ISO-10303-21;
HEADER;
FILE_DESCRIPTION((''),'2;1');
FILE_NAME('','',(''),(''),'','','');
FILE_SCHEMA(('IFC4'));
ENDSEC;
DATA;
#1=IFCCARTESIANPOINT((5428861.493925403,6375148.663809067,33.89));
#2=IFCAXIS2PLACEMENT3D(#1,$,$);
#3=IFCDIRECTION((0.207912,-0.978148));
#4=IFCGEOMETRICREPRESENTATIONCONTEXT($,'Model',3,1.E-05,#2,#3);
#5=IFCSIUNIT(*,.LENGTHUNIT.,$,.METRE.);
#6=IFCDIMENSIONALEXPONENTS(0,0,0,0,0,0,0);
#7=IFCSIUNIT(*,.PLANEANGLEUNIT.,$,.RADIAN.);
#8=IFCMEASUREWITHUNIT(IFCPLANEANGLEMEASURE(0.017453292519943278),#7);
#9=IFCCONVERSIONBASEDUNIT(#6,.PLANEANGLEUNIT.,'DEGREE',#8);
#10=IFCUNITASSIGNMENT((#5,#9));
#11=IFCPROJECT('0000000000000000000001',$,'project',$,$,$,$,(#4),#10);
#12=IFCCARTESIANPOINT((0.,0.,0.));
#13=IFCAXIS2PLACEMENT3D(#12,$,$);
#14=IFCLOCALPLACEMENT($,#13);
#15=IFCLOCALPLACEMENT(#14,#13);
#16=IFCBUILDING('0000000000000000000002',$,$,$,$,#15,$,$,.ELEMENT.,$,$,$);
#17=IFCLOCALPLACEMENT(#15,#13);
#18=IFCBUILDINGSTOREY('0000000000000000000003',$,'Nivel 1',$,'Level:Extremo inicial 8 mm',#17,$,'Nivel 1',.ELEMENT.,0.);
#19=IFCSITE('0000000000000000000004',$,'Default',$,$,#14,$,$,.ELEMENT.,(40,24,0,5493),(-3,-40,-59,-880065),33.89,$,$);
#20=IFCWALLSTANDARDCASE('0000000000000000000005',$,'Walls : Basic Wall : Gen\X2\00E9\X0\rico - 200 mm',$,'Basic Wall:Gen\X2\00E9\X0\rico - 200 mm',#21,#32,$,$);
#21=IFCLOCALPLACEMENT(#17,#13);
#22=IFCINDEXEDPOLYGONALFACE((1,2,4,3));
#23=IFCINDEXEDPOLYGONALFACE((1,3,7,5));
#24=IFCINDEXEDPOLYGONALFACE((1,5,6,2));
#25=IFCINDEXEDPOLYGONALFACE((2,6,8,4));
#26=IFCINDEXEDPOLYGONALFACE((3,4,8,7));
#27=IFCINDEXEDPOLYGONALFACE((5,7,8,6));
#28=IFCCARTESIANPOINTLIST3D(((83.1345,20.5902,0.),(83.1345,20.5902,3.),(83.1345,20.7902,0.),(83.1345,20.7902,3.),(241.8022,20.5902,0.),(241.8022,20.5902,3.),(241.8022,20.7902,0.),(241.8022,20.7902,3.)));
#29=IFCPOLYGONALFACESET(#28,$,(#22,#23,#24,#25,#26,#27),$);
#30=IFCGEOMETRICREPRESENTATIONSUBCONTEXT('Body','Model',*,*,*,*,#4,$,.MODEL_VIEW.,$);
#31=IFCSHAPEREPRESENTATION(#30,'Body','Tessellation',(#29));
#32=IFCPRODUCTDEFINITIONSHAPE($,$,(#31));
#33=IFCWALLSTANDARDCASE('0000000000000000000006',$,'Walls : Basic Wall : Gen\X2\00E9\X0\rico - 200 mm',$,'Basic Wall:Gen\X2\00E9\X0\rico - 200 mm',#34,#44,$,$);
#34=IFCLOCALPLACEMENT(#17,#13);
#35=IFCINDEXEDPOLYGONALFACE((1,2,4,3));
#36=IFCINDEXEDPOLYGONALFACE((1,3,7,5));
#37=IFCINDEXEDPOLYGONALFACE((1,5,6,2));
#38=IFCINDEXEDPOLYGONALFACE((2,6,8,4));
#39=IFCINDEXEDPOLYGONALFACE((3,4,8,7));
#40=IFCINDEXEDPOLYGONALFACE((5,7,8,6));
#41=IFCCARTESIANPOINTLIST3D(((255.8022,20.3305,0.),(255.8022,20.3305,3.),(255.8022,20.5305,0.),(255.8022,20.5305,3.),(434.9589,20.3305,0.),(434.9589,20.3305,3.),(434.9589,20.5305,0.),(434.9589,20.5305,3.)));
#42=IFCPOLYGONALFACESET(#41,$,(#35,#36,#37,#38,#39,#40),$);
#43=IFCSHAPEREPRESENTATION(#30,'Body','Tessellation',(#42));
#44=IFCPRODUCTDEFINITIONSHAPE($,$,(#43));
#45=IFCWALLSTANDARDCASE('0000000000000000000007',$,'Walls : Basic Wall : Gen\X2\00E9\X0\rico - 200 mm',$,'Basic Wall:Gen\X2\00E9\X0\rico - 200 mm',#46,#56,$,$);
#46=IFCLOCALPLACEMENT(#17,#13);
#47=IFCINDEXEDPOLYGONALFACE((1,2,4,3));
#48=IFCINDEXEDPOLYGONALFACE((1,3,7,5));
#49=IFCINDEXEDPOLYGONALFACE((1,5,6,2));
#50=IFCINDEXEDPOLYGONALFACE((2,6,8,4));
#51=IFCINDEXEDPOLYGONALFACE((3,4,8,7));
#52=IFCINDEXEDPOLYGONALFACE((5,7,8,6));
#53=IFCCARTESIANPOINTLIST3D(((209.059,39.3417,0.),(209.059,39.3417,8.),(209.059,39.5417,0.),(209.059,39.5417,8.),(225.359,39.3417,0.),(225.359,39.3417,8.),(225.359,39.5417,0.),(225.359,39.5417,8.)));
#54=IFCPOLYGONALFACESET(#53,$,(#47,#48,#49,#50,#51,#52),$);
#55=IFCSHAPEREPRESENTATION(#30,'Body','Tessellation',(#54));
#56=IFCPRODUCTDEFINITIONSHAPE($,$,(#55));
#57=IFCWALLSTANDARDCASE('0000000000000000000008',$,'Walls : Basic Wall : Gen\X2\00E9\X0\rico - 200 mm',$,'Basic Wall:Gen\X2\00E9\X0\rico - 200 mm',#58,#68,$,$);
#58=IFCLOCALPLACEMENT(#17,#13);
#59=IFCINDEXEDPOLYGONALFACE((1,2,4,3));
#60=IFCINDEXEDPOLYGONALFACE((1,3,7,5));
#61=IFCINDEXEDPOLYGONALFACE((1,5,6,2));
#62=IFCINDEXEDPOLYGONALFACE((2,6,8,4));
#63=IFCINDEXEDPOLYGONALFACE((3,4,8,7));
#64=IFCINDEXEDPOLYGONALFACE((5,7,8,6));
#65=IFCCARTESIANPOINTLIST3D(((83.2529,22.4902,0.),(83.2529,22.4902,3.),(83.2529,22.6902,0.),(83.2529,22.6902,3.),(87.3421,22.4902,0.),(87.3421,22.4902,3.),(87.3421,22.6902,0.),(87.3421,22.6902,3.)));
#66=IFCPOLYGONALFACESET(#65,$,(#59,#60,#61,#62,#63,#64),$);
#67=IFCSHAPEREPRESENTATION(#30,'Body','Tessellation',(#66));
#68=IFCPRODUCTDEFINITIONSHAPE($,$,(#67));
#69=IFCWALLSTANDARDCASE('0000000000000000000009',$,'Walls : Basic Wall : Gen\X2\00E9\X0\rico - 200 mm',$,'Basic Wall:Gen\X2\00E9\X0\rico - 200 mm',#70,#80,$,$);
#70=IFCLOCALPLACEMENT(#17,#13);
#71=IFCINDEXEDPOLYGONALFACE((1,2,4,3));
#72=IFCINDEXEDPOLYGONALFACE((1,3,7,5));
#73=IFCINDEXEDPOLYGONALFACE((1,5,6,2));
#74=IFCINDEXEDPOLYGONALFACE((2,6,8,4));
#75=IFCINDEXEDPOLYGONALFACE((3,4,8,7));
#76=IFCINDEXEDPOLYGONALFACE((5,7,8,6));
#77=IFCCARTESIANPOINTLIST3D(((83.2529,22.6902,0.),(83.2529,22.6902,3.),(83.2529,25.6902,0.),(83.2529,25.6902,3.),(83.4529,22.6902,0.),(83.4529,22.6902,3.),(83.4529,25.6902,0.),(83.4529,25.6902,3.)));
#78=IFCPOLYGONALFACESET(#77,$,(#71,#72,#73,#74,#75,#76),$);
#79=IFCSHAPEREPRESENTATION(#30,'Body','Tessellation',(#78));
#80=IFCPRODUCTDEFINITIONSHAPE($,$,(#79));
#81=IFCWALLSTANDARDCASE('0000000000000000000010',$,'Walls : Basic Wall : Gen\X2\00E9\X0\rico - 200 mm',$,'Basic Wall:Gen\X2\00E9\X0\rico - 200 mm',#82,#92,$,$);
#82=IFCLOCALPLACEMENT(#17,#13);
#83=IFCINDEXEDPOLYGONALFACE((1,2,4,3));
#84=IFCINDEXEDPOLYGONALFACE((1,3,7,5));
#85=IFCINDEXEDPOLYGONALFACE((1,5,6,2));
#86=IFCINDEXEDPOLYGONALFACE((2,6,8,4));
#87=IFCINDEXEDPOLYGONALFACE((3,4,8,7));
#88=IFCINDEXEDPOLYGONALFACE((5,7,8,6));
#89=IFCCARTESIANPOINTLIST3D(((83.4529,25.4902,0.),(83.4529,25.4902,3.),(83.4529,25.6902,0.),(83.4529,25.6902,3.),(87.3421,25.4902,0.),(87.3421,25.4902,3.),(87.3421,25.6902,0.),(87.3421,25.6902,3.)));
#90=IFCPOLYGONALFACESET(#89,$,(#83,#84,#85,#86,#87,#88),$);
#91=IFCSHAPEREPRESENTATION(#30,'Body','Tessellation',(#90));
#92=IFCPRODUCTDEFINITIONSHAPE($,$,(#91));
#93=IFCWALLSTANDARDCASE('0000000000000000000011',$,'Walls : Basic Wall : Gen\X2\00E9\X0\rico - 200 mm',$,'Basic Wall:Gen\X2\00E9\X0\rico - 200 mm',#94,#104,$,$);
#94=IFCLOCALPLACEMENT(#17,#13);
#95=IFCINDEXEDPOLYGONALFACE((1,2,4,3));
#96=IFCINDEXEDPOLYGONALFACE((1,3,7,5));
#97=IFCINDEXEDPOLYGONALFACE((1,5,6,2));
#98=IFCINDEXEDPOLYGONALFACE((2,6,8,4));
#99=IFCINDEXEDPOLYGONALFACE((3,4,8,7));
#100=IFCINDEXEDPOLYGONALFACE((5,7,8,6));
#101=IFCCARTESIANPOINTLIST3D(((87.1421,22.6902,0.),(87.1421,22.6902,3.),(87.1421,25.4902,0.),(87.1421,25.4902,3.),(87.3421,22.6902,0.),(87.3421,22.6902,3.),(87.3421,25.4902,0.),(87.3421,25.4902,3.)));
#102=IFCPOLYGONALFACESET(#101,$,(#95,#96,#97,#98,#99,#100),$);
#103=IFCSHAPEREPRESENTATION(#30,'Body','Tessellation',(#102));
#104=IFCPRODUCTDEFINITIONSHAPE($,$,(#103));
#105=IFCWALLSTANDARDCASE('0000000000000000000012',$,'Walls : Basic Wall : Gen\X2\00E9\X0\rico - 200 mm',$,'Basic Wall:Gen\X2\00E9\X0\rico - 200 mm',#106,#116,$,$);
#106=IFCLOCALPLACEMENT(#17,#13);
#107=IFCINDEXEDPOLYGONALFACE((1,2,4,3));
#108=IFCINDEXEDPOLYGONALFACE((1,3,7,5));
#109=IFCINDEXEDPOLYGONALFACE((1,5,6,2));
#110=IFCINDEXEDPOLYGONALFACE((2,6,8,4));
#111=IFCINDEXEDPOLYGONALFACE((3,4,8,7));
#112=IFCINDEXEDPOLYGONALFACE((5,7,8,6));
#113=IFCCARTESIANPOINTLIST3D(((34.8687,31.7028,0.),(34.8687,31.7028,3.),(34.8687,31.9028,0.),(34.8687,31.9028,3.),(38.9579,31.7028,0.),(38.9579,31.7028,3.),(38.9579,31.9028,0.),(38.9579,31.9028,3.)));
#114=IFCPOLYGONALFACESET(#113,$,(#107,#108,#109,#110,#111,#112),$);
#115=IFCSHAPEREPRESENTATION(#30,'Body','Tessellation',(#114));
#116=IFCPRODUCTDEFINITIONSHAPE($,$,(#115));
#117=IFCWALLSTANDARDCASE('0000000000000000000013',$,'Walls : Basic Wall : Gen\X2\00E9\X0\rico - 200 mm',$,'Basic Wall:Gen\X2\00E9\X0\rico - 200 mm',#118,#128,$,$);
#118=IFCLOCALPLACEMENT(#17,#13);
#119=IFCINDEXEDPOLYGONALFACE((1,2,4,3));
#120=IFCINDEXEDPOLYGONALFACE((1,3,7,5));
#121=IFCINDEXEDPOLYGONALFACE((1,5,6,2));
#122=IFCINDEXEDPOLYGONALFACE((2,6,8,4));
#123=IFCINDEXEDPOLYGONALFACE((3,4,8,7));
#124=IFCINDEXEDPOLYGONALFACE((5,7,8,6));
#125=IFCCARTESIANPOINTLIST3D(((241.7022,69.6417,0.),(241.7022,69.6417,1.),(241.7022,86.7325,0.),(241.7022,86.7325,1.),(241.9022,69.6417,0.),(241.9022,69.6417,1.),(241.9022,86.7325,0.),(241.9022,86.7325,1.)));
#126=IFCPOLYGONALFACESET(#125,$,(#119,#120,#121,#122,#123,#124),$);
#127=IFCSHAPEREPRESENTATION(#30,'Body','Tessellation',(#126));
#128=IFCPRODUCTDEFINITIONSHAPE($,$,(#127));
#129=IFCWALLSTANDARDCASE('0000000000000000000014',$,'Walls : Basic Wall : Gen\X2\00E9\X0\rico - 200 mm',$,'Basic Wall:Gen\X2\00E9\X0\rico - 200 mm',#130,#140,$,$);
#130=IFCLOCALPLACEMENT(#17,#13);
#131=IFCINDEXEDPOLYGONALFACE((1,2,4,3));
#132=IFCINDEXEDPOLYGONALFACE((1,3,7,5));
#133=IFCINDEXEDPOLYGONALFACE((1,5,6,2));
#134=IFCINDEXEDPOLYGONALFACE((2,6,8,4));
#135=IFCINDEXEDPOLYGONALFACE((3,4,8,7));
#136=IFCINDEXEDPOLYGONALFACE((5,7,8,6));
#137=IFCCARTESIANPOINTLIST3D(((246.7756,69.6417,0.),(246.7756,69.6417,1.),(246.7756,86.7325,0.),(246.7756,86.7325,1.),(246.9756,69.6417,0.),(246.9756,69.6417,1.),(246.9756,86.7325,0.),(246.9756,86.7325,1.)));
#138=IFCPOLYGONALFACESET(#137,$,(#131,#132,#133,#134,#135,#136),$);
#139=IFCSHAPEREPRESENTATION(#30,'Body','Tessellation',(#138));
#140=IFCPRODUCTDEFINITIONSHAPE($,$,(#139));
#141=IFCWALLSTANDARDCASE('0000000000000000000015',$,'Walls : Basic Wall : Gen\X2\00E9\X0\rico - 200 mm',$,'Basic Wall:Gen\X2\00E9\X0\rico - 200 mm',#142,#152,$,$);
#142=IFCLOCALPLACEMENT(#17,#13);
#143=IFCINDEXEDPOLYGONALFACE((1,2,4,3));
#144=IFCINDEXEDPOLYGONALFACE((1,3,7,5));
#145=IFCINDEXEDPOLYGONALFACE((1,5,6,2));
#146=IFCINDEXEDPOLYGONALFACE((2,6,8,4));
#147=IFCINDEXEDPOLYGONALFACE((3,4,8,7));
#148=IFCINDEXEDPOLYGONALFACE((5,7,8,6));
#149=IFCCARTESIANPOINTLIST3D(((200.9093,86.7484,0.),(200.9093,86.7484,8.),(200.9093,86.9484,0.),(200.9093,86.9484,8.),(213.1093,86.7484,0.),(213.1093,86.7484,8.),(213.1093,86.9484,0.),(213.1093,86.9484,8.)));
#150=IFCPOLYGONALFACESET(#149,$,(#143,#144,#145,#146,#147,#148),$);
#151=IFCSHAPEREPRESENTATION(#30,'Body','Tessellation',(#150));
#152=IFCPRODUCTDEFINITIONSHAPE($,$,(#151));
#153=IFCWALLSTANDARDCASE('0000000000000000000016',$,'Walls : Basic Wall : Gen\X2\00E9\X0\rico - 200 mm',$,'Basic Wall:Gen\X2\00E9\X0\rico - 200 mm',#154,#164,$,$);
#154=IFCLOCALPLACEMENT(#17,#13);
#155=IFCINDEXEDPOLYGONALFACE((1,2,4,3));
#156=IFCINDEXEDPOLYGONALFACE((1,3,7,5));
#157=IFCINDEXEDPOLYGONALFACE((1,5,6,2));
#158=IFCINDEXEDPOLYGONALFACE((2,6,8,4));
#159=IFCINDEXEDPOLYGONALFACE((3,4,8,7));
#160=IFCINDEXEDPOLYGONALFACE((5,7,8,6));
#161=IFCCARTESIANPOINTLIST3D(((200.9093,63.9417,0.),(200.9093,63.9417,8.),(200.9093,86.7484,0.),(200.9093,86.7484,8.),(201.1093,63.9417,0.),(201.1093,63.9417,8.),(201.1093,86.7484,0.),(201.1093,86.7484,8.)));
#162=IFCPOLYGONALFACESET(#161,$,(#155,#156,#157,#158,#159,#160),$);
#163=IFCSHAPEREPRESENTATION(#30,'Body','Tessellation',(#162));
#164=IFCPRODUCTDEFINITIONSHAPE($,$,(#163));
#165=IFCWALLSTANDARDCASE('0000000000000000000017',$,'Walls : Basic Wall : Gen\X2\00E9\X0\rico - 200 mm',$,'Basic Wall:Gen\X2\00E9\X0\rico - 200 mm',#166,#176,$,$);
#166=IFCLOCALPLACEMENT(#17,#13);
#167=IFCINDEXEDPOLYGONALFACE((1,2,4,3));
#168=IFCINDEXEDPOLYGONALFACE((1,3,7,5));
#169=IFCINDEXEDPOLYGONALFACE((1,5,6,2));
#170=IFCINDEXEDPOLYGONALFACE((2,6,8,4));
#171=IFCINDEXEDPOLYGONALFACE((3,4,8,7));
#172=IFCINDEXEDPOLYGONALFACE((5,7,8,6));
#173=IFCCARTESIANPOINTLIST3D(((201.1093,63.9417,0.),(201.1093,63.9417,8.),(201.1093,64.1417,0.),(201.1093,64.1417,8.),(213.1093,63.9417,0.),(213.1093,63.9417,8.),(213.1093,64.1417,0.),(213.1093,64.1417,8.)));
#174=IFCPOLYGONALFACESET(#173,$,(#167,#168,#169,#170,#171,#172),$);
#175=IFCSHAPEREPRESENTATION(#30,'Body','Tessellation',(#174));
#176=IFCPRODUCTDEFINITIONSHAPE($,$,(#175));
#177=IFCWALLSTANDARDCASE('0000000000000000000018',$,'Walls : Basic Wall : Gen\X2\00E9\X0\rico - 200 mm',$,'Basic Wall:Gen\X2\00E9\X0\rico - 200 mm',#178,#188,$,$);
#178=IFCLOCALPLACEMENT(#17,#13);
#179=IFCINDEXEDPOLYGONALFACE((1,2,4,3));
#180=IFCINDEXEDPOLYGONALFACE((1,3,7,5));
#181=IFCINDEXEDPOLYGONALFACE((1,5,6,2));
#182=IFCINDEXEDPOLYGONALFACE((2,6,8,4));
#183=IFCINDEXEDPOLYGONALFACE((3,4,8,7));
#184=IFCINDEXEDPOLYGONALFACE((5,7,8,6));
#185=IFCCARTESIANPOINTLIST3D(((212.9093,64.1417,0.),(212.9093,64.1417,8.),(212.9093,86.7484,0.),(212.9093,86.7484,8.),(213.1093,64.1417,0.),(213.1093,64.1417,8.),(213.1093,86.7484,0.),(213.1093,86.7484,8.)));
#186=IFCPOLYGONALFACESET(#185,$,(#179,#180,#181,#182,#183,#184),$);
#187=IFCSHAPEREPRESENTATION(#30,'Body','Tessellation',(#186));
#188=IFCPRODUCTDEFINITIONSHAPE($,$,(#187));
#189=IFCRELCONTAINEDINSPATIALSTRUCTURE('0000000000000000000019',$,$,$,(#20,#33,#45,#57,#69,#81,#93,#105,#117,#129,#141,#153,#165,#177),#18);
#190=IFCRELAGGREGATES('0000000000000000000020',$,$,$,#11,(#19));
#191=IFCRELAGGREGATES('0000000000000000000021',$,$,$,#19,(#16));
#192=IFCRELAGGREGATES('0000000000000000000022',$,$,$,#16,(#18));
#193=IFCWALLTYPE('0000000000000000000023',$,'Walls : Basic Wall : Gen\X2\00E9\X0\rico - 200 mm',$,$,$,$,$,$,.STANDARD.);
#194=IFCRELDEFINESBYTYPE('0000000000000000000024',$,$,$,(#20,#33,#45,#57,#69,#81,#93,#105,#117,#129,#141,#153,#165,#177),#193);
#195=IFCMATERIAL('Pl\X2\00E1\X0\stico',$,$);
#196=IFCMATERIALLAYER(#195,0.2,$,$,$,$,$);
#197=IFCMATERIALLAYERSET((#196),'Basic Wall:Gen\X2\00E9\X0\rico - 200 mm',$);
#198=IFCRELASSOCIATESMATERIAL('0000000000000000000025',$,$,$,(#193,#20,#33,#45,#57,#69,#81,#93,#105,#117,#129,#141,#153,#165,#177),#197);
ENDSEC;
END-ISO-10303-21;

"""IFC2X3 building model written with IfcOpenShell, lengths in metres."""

from ifc_helpers import new_model, entity, si_unit, converted_unit, direction, frame, frame_2d, origin, place, context, subcontext, project, spatial, rectangle, extrude, material, layer, layer_set, layer_usage, type_object, element, save


model = new_model("IFC2X3")

# Units and contexts
model_context = context("Model", 3, precision=1e-05, world=frame((5428861.493925403, 6375148.663809067, 33.89)), true_north=direction((0.207912, -0.978148)))
body_context = subcontext(model_context, "Body", "Model", "MODEL_VIEW")
ifc_project = project(units=[si_unit("LENGTHUNIT", "METRE"), converted_unit("PLANEANGLEUNIT", "DEGREE", entity("IfcPlaneAngleMeasure", 0.017453292519943278), si_unit("PLANEANGLEUNIT", "RADIAN"), dimensions=[0, 0, 0, 0, 0, 0, 0])], contexts=[model_context])

# Site, building, storey
site_placement = place(None, origin())
site = spatial("IfcSite", under=ifc_project, at=site_placement, Name="Default", CompositionType="ELEMENT", RefLatitude=(40, 24, 0, 5493), RefLongitude=(-3, -40, -59, -880065), RefElevation=33.89)
building_placement = place(site_placement, origin())
building = spatial("IfcBuilding", under=site, at=building_placement, CompositionType="ELEMENT")
storey_placement = place(building_placement, origin())
storey = spatial("IfcBuildingStorey", under=building, at=storey_placement, Name="Nivel 1", ObjectType="Level:Extremo inicial 8 mm", LongName="Nivel 1", CompositionType="ELEMENT", Elevation=0.0)

# Walls
ifc_material_1 = material(Name="Plástico")
ifc_layer_1 = layer(ifc_material_1, 0.2)
ifc_layer_set_1 = layer_set([ifc_layer_1], Name="Basic Wall:Genérico - 200 mm")
wall_type = type_object("IfcWallType", Name="Walls : Basic Wall : Genérico - 200 mm", PredefinedType="STANDARD", material=ifc_layer_set_1)
ifc_layer_usage_1 = layer_usage(ifc_layer_set_1, "AXIS2", "NEGATIVE", 0.1)
wall_1_placement = place(storey_placement, frame((83.1345, 20.6902, 0.0)))
element("IfcWallStandardCase", 1, at=wall_1_placement, inside=storey, type_object=wall_type, material=ifc_layer_usage_1, Name="Walls : Basic Wall : Genérico - 200 mm", ObjectType="Basic Wall:Genérico - 200 mm", context=body_context, shape_type="SweptSolid", body=[
    extrude(rectangle(XDim=158.6677, YDim=0.2, at=frame_2d((79.3338, 0.0), x_axis=(-1.0, 0.0))), origin(), (0.0, 0.0, 1.0), 3.0),
])
ifc_layer_usage_2 = layer_usage(ifc_layer_set_1, "AXIS2", "NEGATIVE", 0.1)
wall_2_placement = place(storey_placement, frame((255.8022, 20.4305, 0.0)))
element("IfcWallStandardCase", 2, at=wall_2_placement, inside=storey, type_object=wall_type, material=ifc_layer_usage_2, Name="Walls : Basic Wall : Genérico - 200 mm", ObjectType="Basic Wall:Genérico - 200 mm", context=body_context, shape_type="SweptSolid", body=[
    extrude(rectangle(XDim=179.1567, YDim=0.2, at=frame_2d((89.5783, 0.0), x_axis=(-1.0, 0.0))), origin(), (0.0, 0.0, 1.0), 3.0),
])
ifc_layer_usage_3 = layer_usage(ifc_layer_set_1, "AXIS2", "NEGATIVE", 0.1)
wall_3_placement = place(storey_placement, frame((225.359, 39.4417, 0.0), z_axis=(0.0, 0.0, 1.0), x_axis=(-1.0, 0.0, 0.0)))
element("IfcWallStandardCase", 3, at=wall_3_placement, inside=storey, type_object=wall_type, material=ifc_layer_usage_3, Name="Walls : Basic Wall : Genérico - 200 mm", ObjectType="Basic Wall:Genérico - 200 mm", context=body_context, shape_type="SweptSolid", body=[
    extrude(rectangle(XDim=16.3, YDim=0.2, at=frame_2d((8.15, 0.0), x_axis=(-1.0, 0.0))), origin(), (0.0, 0.0, 1.0), 8.0),
])
ifc_layer_usage_4 = layer_usage(ifc_layer_set_1, "AXIS2", "NEGATIVE", 0.1)
wall_4_placement = place(storey_placement, frame((87.3421, 22.5902, 0.0), z_axis=(0.0, 0.0, 1.0), x_axis=(-1.0, 0.0, 0.0)))
element("IfcWallStandardCase", 4, at=wall_4_placement, inside=storey, type_object=wall_type, material=ifc_layer_usage_4, Name="Walls : Basic Wall : Genérico - 200 mm", ObjectType="Basic Wall:Genérico - 200 mm", context=body_context, shape_type="SweptSolid", body=[
    extrude(rectangle(XDim=4.0892, YDim=0.2, at=frame_2d((2.0446, 0.0), x_axis=(-1.0, 0.0))), origin(), (0.0, 0.0, 1.0), 3.0),
])
ifc_layer_usage_5 = layer_usage(ifc_layer_set_1, "AXIS2", "POSITIVE", -0.1)
wall_5_placement = place(storey_placement, frame((83.3529, 22.6902, 0.0), z_axis=(0.0, 0.0, 1.0), x_axis=(0.0, 1.0, 0.0)))
element("IfcWallStandardCase", 5, at=wall_5_placement, inside=storey, type_object=wall_type, material=ifc_layer_usage_5, Name="Walls : Basic Wall : Genérico - 200 mm", ObjectType="Basic Wall:Genérico - 200 mm", context=body_context, shape_type="SweptSolid", body=[
    extrude(rectangle(XDim=3.0, YDim=0.2, at=frame_2d((1.5, 0.0), x_axis=(-1.0, 0.0))), origin(), (0.0, 0.0, 1.0), 3.0),
])
ifc_layer_usage_6 = layer_usage(ifc_layer_set_1, "AXIS2", "NEGATIVE", 0.1)
wall_6_placement = place(storey_placement, frame((83.4529, 25.5902, 0.0)))
element("IfcWallStandardCase", 6, at=wall_6_placement, inside=storey, type_object=wall_type, material=ifc_layer_usage_6, Name="Walls : Basic Wall : Genérico - 200 mm", ObjectType="Basic Wall:Genérico - 200 mm", context=body_context, shape_type="SweptSolid", body=[
    extrude(rectangle(XDim=3.8892, YDim=0.2, at=frame_2d((1.9446, 0.0), x_axis=(-1.0, 0.0))), origin(), (0.0, 0.0, 1.0), 3.0),
])
ifc_layer_usage_7 = layer_usage(ifc_layer_set_1, "AXIS2", "NEGATIVE", 0.1)
wall_7_placement = place(storey_placement, frame((87.2421, 25.4902, 0.0), z_axis=(0.0, 0.0, 1.0), x_axis=(0.0, -1.0, 0.0)))
element("IfcWallStandardCase", 7, at=wall_7_placement, inside=storey, type_object=wall_type, material=ifc_layer_usage_7, Name="Walls : Basic Wall : Genérico - 200 mm", ObjectType="Basic Wall:Genérico - 200 mm", context=body_context, shape_type="SweptSolid", body=[
    extrude(rectangle(XDim=2.8, YDim=0.2, at=frame_2d((1.4, 0.0), x_axis=(-1.0, 0.0))), origin(), (0.0, 0.0, 1.0), 3.0),
])
ifc_layer_usage_8 = layer_usage(ifc_layer_set_1, "AXIS2", "NEGATIVE", 0.1)
wall_8_placement = place(storey_placement, frame((38.9579, 31.8028, 0.0), z_axis=(0.0, 0.0, 1.0), x_axis=(-1.0, 0.0, 0.0)))
element("IfcWallStandardCase", 8, at=wall_8_placement, inside=storey, type_object=wall_type, material=ifc_layer_usage_8, Name="Walls : Basic Wall : Genérico - 200 mm", ObjectType="Basic Wall:Genérico - 200 mm", context=body_context, shape_type="SweptSolid", body=[
    extrude(rectangle(XDim=4.0892, YDim=0.2, at=frame_2d((2.0446, 0.0), x_axis=(-1.0, 0.0))), origin(), (0.0, 0.0, 1.0), 3.0),
])
ifc_layer_usage_9 = layer_usage(ifc_layer_set_1, "AXIS2", "NEGATIVE", 0.1)
wall_9_placement = place(storey_placement, frame((241.8022, 69.6417, 0.0), z_axis=(0.0, 0.0, 1.0), x_axis=(0.0, 1.0, 0.0)))
element("IfcWallStandardCase", 9, at=wall_9_placement, inside=storey, type_object=wall_type, material=ifc_layer_usage_9, Name="Walls : Basic Wall : Genérico - 200 mm", ObjectType="Basic Wall:Genérico - 200 mm", context=body_context, shape_type="SweptSolid", body=[
    extrude(rectangle(XDim=17.0908, YDim=0.2, at=frame_2d((8.5454, 0.0), x_axis=(-1.0, 0.0))), origin(), (0.0, 0.0, 1.0), 1.0),
])
ifc_layer_usage_10 = layer_usage(ifc_layer_set_1, "AXIS2", "NEGATIVE", 0.1)
wall_10_placement = place(storey_placement, frame((246.8756, 69.6417, 0.0), z_axis=(0.0, 0.0, 1.0), x_axis=(0.0, 1.0, 0.0)))
element("IfcWallStandardCase", 10, at=wall_10_placement, inside=storey, type_object=wall_type, material=ifc_layer_usage_10, Name="Walls : Basic Wall : Genérico - 200 mm", ObjectType="Basic Wall:Genérico - 200 mm", context=body_context, shape_type="SweptSolid", body=[
    extrude(rectangle(XDim=17.0908, YDim=0.2, at=frame_2d((8.5454, 0.0), x_axis=(-1.0, 0.0))), origin(), (0.0, 0.0, 1.0), 1.0),
])
ifc_layer_usage_11 = layer_usage(ifc_layer_set_1, "AXIS2", "NEGATIVE", 0.1)
wall_11_placement = place(storey_placement, frame((200.9093, 86.8484, 0.0)))
element("IfcWallStandardCase", 11, at=wall_11_placement, inside=storey, type_object=wall_type, material=ifc_layer_usage_11, Name="Walls : Basic Wall : Genérico - 200 mm", ObjectType="Basic Wall:Genérico - 200 mm", context=body_context, shape_type="SweptSolid", body=[
    extrude(rectangle(XDim=12.2, YDim=0.2, at=frame_2d((6.1, 0.0), x_axis=(-1.0, 0.0))), origin(), (0.0, 0.0, 1.0), 8.0),
])
ifc_layer_usage_12 = layer_usage(ifc_layer_set_1, "AXIS2", "NEGATIVE", 0.1)
wall_12_placement = place(storey_placement, frame((201.0093, 86.7484, 0.0), z_axis=(0.0, 0.0, 1.0), x_axis=(0.0, -1.0, 0.0)))
element("IfcWallStandardCase", 12, at=wall_12_placement, inside=storey, type_object=wall_type, material=ifc_layer_usage_12, Name="Walls : Basic Wall : Genérico - 200 mm", ObjectType="Basic Wall:Genérico - 200 mm", context=body_context, shape_type="SweptSolid", body=[
    extrude(rectangle(XDim=22.8067, YDim=0.2, at=frame_2d((11.4033, 0.0), x_axis=(-1.0, 0.0))), origin(), (0.0, 0.0, 1.0), 8.0),
])
ifc_layer_usage_13 = layer_usage(ifc_layer_set_1, "AXIS2", "NEGATIVE", 0.1)
wall_13_placement = place(storey_placement, frame((213.1093, 64.0417, 0.0), z_axis=(0.0, 0.0, 1.0), x_axis=(-1.0, 0.0, 0.0)))
element("IfcWallStandardCase", 13, at=wall_13_placement, inside=storey, type_object=wall_type, material=ifc_layer_usage_13, Name="Walls : Basic Wall : Genérico - 200 mm", ObjectType="Basic Wall:Genérico - 200 mm", context=body_context, shape_type="SweptSolid", body=[
    extrude(rectangle(XDim=12.0, YDim=0.2, at=frame_2d((6.0, 0.0), x_axis=(-1.0, 0.0))), origin(), (0.0, 0.0, 1.0), 8.0),
])
ifc_layer_usage_14 = layer_usage(ifc_layer_set_1, "AXIS2", "NEGATIVE", 0.1)
wall_14_placement = place(storey_placement, frame((213.0093, 86.7484, 0.0), z_axis=(0.0, 0.0, 1.0), x_axis=(0.0, -1.0, 0.0)))
element("IfcWallStandardCase", 14, at=wall_14_placement, inside=storey, type_object=wall_type, material=ifc_layer_usage_14, Name="Walls : Basic Wall : Genérico - 200 mm", ObjectType="Basic Wall:Genérico - 200 mm", context=body_context, shape_type="SweptSolid", body=[
    extrude(rectangle(XDim=22.6067, YDim=0.2, at=frame_2d((11.3033, 0.0), x_axis=(-1.0, 0.0))), origin(), (0.0, 0.0, 1.0), 8.0),
])

save(model, "model.ifc")
